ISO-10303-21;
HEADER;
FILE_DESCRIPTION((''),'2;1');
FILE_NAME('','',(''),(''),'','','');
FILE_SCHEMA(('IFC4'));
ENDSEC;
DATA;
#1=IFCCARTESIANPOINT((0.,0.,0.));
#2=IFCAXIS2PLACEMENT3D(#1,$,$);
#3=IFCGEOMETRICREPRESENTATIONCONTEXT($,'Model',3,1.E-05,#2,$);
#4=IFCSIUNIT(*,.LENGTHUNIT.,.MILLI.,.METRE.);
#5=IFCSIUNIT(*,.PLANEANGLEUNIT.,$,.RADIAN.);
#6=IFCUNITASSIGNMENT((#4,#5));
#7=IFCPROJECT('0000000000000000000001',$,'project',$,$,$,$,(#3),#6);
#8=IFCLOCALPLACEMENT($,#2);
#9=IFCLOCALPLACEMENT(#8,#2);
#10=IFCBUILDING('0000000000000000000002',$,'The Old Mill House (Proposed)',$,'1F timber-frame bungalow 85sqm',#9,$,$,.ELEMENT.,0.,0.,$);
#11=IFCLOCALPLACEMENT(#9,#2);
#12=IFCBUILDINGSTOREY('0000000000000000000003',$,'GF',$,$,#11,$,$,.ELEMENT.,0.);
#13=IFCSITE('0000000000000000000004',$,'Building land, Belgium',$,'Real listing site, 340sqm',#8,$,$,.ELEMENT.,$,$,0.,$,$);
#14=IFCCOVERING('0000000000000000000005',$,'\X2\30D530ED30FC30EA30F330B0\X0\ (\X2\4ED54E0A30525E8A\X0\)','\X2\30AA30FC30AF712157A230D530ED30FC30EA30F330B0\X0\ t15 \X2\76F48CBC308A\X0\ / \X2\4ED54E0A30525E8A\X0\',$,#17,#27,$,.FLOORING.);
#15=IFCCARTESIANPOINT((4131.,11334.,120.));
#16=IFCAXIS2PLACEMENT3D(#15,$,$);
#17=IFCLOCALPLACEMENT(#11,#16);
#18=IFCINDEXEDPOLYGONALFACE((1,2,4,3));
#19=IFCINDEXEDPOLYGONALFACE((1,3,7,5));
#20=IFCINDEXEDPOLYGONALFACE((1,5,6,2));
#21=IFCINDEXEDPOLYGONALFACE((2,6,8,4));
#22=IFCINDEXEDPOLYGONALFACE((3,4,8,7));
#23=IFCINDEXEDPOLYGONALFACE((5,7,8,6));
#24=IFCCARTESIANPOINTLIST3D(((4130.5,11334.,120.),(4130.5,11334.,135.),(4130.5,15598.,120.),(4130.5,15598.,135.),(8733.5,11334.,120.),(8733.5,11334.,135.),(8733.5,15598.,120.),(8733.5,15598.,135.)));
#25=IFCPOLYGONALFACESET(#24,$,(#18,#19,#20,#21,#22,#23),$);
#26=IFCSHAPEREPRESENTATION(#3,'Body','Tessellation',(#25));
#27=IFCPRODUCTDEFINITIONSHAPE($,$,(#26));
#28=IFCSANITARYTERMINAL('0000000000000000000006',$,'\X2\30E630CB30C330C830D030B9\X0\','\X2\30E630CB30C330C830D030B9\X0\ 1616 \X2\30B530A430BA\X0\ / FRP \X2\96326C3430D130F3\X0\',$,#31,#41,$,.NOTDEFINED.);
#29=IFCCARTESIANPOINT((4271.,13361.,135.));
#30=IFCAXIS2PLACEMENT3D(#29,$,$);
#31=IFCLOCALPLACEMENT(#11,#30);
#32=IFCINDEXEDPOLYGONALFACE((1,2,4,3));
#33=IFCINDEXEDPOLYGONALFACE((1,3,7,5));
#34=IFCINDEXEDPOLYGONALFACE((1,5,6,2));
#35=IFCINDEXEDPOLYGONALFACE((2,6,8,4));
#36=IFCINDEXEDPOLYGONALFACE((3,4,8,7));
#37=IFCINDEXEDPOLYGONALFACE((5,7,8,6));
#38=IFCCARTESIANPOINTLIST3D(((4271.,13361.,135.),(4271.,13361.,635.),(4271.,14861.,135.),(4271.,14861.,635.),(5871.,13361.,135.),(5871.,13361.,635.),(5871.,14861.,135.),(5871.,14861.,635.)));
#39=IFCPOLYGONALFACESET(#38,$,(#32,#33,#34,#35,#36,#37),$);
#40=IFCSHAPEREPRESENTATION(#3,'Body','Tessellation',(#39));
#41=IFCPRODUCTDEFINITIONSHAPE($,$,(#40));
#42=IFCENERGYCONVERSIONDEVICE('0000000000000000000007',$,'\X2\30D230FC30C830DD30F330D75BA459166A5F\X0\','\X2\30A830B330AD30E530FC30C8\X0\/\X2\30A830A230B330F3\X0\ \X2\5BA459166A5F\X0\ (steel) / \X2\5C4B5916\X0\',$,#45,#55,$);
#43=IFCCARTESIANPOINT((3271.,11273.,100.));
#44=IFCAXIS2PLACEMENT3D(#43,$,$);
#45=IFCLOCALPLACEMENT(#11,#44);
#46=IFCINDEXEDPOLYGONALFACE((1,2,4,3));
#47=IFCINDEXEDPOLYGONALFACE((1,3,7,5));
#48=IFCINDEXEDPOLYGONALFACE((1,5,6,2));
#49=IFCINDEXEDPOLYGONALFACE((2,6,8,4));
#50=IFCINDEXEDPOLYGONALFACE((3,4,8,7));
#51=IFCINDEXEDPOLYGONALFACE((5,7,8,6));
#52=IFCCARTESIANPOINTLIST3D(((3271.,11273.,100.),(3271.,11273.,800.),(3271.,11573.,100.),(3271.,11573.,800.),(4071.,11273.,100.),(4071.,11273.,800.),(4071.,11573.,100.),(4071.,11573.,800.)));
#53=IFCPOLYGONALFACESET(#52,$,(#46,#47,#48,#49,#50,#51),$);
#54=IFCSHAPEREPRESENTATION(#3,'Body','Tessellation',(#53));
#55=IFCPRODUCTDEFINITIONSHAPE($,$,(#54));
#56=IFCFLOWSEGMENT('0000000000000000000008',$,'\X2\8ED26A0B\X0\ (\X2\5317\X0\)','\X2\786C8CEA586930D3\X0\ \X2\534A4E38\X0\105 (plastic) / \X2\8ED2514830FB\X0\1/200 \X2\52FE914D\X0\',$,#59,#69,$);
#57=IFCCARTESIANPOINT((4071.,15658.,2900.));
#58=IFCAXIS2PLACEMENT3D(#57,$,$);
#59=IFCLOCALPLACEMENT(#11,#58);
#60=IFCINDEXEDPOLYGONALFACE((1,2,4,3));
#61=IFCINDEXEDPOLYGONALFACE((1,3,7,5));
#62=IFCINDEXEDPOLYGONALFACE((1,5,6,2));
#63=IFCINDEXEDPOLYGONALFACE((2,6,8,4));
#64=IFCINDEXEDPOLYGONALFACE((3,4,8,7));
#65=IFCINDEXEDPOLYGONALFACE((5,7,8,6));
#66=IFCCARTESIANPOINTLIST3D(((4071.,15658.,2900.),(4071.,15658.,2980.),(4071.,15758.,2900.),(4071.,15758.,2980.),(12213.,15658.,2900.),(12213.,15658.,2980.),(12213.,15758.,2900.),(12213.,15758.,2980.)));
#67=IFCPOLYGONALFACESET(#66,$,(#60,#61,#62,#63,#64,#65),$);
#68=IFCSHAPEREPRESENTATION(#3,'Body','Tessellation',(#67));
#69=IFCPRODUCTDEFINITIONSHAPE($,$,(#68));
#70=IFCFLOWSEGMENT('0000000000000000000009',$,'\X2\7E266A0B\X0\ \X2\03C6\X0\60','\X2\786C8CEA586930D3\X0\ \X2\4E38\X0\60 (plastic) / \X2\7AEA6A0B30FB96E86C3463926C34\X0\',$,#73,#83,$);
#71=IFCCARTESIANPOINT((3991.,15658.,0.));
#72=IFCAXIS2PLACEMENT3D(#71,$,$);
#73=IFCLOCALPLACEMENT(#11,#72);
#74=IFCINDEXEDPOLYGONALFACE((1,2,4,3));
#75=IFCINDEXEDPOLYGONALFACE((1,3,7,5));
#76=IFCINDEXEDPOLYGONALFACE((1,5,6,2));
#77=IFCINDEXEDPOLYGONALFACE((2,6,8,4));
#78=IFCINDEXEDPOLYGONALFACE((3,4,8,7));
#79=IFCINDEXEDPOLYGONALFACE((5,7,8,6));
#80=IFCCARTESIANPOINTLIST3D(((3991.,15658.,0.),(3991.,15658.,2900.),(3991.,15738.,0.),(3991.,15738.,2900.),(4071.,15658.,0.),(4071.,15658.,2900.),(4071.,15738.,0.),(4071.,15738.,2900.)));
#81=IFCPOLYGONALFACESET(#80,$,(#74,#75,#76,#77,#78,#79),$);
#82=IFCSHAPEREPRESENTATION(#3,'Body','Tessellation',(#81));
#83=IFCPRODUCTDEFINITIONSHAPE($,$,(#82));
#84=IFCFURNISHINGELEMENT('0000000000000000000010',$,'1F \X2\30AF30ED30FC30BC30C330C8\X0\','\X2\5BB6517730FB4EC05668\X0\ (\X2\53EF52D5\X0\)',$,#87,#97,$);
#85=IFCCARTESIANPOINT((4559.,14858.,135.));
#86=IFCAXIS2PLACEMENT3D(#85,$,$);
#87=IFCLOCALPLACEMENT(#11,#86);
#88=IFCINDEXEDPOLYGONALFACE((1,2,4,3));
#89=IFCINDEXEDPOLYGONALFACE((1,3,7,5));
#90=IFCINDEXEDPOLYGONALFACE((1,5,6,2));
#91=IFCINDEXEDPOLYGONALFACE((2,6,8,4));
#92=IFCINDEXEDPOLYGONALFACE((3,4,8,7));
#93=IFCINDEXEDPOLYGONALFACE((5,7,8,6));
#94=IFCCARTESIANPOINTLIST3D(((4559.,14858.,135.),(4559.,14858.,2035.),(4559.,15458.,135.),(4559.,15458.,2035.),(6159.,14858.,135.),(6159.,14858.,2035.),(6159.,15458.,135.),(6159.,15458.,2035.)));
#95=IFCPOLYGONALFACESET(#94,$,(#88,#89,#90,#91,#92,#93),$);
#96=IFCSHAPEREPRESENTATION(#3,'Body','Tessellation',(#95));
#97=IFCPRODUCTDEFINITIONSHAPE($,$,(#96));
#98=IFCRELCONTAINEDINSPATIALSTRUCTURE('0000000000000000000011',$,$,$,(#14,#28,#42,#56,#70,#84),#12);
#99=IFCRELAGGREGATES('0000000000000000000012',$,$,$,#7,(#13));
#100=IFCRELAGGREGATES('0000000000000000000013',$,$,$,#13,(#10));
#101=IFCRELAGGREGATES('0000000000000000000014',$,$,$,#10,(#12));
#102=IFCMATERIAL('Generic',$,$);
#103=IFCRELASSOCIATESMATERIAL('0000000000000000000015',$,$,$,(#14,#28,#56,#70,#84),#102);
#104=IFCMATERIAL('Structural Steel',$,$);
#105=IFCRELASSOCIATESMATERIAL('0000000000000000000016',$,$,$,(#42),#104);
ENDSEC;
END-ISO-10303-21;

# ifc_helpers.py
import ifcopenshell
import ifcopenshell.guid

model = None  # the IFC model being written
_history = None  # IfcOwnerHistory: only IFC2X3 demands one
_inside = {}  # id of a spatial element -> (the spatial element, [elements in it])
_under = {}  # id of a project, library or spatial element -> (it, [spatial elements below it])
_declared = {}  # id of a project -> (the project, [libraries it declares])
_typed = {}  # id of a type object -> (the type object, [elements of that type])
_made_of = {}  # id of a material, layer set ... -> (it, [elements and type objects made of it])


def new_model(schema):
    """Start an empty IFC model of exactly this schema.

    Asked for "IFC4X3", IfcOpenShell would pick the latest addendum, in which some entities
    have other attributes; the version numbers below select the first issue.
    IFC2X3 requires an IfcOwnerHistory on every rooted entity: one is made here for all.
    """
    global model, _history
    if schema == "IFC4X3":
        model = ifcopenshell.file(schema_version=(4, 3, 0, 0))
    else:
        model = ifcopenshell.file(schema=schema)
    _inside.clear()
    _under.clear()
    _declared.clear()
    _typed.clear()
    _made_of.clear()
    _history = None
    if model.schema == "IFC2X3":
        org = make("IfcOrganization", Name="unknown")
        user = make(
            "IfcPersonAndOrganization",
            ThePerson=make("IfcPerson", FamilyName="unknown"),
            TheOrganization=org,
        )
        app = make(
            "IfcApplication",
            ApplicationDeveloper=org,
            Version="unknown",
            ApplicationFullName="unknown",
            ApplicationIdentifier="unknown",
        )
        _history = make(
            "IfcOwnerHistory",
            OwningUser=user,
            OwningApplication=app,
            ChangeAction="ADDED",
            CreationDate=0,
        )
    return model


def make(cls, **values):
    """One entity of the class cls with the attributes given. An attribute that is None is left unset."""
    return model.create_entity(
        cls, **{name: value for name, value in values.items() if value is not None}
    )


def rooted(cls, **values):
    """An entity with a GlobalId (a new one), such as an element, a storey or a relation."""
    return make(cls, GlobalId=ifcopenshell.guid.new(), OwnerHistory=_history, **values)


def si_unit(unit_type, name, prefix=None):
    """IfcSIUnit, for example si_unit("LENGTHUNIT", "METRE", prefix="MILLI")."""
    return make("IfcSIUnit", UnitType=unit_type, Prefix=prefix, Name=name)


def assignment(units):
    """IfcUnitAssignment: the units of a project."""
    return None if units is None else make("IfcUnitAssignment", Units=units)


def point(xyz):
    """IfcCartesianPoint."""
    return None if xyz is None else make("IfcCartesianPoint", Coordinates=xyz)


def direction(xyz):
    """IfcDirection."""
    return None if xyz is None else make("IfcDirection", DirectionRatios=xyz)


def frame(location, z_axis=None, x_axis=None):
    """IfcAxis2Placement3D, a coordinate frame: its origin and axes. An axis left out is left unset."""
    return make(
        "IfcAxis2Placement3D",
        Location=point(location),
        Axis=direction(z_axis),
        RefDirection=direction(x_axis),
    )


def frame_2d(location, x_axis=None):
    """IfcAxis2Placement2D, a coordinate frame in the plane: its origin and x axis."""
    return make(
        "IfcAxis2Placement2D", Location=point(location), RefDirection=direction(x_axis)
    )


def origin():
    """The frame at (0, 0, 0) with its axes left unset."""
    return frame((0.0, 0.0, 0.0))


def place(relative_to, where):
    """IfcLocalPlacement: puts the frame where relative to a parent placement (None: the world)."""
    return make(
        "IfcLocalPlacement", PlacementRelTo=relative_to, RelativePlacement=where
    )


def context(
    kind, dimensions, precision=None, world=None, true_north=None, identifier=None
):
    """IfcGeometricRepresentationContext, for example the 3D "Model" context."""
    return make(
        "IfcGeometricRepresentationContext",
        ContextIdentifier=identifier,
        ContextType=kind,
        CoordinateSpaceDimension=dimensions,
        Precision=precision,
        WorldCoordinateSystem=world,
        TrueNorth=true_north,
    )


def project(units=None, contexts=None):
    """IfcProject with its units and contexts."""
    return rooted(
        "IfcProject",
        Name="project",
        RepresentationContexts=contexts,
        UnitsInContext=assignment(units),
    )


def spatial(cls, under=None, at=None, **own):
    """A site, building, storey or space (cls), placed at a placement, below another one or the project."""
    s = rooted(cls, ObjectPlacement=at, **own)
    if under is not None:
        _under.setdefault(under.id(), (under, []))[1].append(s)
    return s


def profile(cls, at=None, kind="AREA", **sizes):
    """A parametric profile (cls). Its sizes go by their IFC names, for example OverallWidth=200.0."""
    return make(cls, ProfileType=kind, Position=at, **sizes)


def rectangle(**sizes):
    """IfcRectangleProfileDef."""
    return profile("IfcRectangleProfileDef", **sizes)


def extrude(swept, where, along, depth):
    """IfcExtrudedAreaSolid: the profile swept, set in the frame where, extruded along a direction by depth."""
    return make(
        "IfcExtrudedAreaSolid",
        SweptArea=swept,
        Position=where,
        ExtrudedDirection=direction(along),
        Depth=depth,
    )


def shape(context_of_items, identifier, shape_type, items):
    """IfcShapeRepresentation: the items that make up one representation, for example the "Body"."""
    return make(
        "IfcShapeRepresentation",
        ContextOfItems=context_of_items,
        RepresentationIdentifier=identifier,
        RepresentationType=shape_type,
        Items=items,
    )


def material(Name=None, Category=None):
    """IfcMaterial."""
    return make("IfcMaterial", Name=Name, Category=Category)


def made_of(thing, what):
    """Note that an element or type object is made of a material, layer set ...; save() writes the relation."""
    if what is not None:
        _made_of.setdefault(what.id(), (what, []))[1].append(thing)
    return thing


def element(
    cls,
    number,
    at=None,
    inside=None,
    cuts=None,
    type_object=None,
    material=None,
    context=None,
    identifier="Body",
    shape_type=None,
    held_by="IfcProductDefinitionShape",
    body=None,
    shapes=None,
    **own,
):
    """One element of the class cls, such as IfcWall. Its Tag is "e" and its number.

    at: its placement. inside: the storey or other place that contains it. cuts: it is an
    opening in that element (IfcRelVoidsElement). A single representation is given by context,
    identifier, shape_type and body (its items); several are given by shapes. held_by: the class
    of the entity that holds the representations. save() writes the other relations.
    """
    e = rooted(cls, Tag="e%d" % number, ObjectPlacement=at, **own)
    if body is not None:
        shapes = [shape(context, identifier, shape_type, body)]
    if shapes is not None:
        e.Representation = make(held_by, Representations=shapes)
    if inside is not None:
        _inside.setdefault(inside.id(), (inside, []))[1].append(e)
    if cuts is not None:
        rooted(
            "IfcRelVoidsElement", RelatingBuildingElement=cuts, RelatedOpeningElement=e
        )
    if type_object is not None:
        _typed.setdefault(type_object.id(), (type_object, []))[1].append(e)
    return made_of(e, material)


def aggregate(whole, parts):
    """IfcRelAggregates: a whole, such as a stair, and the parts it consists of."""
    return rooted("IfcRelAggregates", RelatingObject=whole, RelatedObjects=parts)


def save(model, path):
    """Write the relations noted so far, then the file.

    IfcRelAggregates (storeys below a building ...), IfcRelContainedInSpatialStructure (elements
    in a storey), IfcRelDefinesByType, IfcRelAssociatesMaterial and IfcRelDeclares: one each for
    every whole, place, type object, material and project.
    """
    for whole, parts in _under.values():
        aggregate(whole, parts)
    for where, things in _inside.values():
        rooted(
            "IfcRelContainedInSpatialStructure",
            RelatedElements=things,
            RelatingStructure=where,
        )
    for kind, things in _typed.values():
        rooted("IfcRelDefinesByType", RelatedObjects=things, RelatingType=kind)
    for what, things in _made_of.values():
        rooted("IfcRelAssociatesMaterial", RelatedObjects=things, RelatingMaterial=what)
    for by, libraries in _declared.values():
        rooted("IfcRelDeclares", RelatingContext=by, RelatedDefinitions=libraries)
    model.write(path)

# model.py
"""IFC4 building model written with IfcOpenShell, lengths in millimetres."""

from ifc_helpers import new_model, si_unit, frame, frame_2d, origin, place, context, project, spatial, rectangle, extrude, material, element, save


model = new_model("IFC4")

# Units and contexts
model_context = context("Model", 3, precision=1e-05, world=origin())
ifc_project = project(units=[si_unit("LENGTHUNIT", "METRE", prefix="MILLI"), si_unit("PLANEANGLEUNIT", "RADIAN")], contexts=[model_context])

# Site, building, storey
site_placement = place(None, origin())
site = spatial("IfcSite", under=ifc_project, at=site_placement, Name="Building land, Belgium", ObjectType="Real listing site, 340sqm", CompositionType="ELEMENT", RefElevation=0.0)
building_placement = place(site_placement, origin())
building = spatial("IfcBuilding", under=site, at=building_placement, Name="The Old Mill House (Proposed)", ObjectType="1F timber-frame bungalow 85sqm", CompositionType="ELEMENT", ElevationOfRefHeight=0.0, ElevationOfTerrain=0.0)
storey_placement = place(building_placement, origin())
storey = spatial("IfcBuildingStorey", under=building, at=storey_placement, Name="GF", CompositionType="ELEMENT", Elevation=0.0)

# Shared definitions
ifc_material_1 = material(Name="Structural Steel")

# Covering
ifc_material_2 = material(Name="Generic")
covering_placement = place(storey_placement, frame((4131.0, 11334.0, 120.0)))
element("IfcCovering", 1, at=covering_placement, inside=storey, material=ifc_material_2, Name="フローリング (仕上げ床)", Description="オーク無垢フローリング t15 直貼り / 仕上げ床", PredefinedType="FLOORING", context=model_context, shape_type="SweptSolid", body=[
    extrude(rectangle(XDim=4603.0, YDim=4264.0, at=frame_2d((2301.0, 2132.0))), frame((4131.0, 11334.0, 120.0)), (0.0, 0.0, 1.0), 15.0),
])

# Sanitary terminal
sanitary_terminal_placement = place(storey_placement, frame((4271.0, 13361.0, 135.0)))
element("IfcSanitaryTerminal", 2, at=sanitary_terminal_placement, inside=storey, material=ifc_material_2, Name="ユニットバス", Description="ユニットバス 1616 サイズ / FRP 防水パン", PredefinedType="NOTDEFINED", context=model_context, shape_type="SweptSolid", body=[
    extrude(rectangle(XDim=1600.0, YDim=1500.0, at=frame_2d((800.0, 750.0))), frame((4271.0, 13361.0, 135.0)), (0.0, 0.0, 1.0), 500.0),
])

# Energy conversion device
energy_conversion_device_placement = place(storey_placement, frame((3271.0, 11273.0, 100.0)))
element("IfcEnergyConversionDevice", 3, at=energy_conversion_device_placement, inside=storey, material=ifc_material_1, Name="ヒートポンプ室外機", Description="エコキュート/エアコン 室外機 (steel) / 屋外", context=model_context, shape_type="SweptSolid", body=[
    extrude(rectangle(XDim=800.0, YDim=300.0, at=frame_2d((400.0, 150.0))), frame((3271.0, 11273.0, 100.0)), (0.0, 0.0, 1.0), 700.0),
])

# Flow segments
flow_segment_1_placement = place(storey_placement, frame((4071.0, 15658.0, 2900.0)))
element("IfcFlowSegment", 4, at=flow_segment_1_placement, inside=storey, material=ifc_material_2, Name="軒樋 (北)", Description="硬質塩ビ 半丸105 (plastic) / 軒先・1/200 勾配", context=model_context, shape_type="SweptSolid", body=[
    extrude(rectangle(XDim=8142.0, YDim=100.0, at=frame_2d((4071.0, 50.0))), frame((4071.0, 15658.0, 2900.0)), (0.0, 0.0, 1.0), 80.0),
])
flow_segment_2_placement = place(storey_placement, frame((3991.0, 15658.0, 0.0)))
element("IfcFlowSegment", 5, at=flow_segment_2_placement, inside=storey, material=ifc_material_2, Name="縦樋 φ60", Description="硬質塩ビ 丸60 (plastic) / 竪樋・雨水排水", context=model_context, shape_type="SweptSolid", body=[
    extrude(rectangle(XDim=80.0, YDim=80.0, at=frame_2d((40.0, 40.0))), frame((3991.0, 15658.0, 0.0)), (0.0, 0.0, 1.0), 2900.0),
])

# Furnishing element
furnishing_placement = place(storey_placement, frame((4559.0, 14858.0, 135.0)))
element("IfcFurnishingElement", 6, at=furnishing_placement, inside=storey, material=ifc_material_2, Name="1F クローゼット", Description="家具・什器 (可動)", context=model_context, shape_type="SweptSolid", body=[
    extrude(rectangle(XDim=1600.0, YDim=600.0, at=frame_2d((800.0, 300.0))), frame((4559.0, 14858.0, 135.0)), (0.0, 0.0, 1.0), 1900.0),
])

save(model, "model.ifc")
